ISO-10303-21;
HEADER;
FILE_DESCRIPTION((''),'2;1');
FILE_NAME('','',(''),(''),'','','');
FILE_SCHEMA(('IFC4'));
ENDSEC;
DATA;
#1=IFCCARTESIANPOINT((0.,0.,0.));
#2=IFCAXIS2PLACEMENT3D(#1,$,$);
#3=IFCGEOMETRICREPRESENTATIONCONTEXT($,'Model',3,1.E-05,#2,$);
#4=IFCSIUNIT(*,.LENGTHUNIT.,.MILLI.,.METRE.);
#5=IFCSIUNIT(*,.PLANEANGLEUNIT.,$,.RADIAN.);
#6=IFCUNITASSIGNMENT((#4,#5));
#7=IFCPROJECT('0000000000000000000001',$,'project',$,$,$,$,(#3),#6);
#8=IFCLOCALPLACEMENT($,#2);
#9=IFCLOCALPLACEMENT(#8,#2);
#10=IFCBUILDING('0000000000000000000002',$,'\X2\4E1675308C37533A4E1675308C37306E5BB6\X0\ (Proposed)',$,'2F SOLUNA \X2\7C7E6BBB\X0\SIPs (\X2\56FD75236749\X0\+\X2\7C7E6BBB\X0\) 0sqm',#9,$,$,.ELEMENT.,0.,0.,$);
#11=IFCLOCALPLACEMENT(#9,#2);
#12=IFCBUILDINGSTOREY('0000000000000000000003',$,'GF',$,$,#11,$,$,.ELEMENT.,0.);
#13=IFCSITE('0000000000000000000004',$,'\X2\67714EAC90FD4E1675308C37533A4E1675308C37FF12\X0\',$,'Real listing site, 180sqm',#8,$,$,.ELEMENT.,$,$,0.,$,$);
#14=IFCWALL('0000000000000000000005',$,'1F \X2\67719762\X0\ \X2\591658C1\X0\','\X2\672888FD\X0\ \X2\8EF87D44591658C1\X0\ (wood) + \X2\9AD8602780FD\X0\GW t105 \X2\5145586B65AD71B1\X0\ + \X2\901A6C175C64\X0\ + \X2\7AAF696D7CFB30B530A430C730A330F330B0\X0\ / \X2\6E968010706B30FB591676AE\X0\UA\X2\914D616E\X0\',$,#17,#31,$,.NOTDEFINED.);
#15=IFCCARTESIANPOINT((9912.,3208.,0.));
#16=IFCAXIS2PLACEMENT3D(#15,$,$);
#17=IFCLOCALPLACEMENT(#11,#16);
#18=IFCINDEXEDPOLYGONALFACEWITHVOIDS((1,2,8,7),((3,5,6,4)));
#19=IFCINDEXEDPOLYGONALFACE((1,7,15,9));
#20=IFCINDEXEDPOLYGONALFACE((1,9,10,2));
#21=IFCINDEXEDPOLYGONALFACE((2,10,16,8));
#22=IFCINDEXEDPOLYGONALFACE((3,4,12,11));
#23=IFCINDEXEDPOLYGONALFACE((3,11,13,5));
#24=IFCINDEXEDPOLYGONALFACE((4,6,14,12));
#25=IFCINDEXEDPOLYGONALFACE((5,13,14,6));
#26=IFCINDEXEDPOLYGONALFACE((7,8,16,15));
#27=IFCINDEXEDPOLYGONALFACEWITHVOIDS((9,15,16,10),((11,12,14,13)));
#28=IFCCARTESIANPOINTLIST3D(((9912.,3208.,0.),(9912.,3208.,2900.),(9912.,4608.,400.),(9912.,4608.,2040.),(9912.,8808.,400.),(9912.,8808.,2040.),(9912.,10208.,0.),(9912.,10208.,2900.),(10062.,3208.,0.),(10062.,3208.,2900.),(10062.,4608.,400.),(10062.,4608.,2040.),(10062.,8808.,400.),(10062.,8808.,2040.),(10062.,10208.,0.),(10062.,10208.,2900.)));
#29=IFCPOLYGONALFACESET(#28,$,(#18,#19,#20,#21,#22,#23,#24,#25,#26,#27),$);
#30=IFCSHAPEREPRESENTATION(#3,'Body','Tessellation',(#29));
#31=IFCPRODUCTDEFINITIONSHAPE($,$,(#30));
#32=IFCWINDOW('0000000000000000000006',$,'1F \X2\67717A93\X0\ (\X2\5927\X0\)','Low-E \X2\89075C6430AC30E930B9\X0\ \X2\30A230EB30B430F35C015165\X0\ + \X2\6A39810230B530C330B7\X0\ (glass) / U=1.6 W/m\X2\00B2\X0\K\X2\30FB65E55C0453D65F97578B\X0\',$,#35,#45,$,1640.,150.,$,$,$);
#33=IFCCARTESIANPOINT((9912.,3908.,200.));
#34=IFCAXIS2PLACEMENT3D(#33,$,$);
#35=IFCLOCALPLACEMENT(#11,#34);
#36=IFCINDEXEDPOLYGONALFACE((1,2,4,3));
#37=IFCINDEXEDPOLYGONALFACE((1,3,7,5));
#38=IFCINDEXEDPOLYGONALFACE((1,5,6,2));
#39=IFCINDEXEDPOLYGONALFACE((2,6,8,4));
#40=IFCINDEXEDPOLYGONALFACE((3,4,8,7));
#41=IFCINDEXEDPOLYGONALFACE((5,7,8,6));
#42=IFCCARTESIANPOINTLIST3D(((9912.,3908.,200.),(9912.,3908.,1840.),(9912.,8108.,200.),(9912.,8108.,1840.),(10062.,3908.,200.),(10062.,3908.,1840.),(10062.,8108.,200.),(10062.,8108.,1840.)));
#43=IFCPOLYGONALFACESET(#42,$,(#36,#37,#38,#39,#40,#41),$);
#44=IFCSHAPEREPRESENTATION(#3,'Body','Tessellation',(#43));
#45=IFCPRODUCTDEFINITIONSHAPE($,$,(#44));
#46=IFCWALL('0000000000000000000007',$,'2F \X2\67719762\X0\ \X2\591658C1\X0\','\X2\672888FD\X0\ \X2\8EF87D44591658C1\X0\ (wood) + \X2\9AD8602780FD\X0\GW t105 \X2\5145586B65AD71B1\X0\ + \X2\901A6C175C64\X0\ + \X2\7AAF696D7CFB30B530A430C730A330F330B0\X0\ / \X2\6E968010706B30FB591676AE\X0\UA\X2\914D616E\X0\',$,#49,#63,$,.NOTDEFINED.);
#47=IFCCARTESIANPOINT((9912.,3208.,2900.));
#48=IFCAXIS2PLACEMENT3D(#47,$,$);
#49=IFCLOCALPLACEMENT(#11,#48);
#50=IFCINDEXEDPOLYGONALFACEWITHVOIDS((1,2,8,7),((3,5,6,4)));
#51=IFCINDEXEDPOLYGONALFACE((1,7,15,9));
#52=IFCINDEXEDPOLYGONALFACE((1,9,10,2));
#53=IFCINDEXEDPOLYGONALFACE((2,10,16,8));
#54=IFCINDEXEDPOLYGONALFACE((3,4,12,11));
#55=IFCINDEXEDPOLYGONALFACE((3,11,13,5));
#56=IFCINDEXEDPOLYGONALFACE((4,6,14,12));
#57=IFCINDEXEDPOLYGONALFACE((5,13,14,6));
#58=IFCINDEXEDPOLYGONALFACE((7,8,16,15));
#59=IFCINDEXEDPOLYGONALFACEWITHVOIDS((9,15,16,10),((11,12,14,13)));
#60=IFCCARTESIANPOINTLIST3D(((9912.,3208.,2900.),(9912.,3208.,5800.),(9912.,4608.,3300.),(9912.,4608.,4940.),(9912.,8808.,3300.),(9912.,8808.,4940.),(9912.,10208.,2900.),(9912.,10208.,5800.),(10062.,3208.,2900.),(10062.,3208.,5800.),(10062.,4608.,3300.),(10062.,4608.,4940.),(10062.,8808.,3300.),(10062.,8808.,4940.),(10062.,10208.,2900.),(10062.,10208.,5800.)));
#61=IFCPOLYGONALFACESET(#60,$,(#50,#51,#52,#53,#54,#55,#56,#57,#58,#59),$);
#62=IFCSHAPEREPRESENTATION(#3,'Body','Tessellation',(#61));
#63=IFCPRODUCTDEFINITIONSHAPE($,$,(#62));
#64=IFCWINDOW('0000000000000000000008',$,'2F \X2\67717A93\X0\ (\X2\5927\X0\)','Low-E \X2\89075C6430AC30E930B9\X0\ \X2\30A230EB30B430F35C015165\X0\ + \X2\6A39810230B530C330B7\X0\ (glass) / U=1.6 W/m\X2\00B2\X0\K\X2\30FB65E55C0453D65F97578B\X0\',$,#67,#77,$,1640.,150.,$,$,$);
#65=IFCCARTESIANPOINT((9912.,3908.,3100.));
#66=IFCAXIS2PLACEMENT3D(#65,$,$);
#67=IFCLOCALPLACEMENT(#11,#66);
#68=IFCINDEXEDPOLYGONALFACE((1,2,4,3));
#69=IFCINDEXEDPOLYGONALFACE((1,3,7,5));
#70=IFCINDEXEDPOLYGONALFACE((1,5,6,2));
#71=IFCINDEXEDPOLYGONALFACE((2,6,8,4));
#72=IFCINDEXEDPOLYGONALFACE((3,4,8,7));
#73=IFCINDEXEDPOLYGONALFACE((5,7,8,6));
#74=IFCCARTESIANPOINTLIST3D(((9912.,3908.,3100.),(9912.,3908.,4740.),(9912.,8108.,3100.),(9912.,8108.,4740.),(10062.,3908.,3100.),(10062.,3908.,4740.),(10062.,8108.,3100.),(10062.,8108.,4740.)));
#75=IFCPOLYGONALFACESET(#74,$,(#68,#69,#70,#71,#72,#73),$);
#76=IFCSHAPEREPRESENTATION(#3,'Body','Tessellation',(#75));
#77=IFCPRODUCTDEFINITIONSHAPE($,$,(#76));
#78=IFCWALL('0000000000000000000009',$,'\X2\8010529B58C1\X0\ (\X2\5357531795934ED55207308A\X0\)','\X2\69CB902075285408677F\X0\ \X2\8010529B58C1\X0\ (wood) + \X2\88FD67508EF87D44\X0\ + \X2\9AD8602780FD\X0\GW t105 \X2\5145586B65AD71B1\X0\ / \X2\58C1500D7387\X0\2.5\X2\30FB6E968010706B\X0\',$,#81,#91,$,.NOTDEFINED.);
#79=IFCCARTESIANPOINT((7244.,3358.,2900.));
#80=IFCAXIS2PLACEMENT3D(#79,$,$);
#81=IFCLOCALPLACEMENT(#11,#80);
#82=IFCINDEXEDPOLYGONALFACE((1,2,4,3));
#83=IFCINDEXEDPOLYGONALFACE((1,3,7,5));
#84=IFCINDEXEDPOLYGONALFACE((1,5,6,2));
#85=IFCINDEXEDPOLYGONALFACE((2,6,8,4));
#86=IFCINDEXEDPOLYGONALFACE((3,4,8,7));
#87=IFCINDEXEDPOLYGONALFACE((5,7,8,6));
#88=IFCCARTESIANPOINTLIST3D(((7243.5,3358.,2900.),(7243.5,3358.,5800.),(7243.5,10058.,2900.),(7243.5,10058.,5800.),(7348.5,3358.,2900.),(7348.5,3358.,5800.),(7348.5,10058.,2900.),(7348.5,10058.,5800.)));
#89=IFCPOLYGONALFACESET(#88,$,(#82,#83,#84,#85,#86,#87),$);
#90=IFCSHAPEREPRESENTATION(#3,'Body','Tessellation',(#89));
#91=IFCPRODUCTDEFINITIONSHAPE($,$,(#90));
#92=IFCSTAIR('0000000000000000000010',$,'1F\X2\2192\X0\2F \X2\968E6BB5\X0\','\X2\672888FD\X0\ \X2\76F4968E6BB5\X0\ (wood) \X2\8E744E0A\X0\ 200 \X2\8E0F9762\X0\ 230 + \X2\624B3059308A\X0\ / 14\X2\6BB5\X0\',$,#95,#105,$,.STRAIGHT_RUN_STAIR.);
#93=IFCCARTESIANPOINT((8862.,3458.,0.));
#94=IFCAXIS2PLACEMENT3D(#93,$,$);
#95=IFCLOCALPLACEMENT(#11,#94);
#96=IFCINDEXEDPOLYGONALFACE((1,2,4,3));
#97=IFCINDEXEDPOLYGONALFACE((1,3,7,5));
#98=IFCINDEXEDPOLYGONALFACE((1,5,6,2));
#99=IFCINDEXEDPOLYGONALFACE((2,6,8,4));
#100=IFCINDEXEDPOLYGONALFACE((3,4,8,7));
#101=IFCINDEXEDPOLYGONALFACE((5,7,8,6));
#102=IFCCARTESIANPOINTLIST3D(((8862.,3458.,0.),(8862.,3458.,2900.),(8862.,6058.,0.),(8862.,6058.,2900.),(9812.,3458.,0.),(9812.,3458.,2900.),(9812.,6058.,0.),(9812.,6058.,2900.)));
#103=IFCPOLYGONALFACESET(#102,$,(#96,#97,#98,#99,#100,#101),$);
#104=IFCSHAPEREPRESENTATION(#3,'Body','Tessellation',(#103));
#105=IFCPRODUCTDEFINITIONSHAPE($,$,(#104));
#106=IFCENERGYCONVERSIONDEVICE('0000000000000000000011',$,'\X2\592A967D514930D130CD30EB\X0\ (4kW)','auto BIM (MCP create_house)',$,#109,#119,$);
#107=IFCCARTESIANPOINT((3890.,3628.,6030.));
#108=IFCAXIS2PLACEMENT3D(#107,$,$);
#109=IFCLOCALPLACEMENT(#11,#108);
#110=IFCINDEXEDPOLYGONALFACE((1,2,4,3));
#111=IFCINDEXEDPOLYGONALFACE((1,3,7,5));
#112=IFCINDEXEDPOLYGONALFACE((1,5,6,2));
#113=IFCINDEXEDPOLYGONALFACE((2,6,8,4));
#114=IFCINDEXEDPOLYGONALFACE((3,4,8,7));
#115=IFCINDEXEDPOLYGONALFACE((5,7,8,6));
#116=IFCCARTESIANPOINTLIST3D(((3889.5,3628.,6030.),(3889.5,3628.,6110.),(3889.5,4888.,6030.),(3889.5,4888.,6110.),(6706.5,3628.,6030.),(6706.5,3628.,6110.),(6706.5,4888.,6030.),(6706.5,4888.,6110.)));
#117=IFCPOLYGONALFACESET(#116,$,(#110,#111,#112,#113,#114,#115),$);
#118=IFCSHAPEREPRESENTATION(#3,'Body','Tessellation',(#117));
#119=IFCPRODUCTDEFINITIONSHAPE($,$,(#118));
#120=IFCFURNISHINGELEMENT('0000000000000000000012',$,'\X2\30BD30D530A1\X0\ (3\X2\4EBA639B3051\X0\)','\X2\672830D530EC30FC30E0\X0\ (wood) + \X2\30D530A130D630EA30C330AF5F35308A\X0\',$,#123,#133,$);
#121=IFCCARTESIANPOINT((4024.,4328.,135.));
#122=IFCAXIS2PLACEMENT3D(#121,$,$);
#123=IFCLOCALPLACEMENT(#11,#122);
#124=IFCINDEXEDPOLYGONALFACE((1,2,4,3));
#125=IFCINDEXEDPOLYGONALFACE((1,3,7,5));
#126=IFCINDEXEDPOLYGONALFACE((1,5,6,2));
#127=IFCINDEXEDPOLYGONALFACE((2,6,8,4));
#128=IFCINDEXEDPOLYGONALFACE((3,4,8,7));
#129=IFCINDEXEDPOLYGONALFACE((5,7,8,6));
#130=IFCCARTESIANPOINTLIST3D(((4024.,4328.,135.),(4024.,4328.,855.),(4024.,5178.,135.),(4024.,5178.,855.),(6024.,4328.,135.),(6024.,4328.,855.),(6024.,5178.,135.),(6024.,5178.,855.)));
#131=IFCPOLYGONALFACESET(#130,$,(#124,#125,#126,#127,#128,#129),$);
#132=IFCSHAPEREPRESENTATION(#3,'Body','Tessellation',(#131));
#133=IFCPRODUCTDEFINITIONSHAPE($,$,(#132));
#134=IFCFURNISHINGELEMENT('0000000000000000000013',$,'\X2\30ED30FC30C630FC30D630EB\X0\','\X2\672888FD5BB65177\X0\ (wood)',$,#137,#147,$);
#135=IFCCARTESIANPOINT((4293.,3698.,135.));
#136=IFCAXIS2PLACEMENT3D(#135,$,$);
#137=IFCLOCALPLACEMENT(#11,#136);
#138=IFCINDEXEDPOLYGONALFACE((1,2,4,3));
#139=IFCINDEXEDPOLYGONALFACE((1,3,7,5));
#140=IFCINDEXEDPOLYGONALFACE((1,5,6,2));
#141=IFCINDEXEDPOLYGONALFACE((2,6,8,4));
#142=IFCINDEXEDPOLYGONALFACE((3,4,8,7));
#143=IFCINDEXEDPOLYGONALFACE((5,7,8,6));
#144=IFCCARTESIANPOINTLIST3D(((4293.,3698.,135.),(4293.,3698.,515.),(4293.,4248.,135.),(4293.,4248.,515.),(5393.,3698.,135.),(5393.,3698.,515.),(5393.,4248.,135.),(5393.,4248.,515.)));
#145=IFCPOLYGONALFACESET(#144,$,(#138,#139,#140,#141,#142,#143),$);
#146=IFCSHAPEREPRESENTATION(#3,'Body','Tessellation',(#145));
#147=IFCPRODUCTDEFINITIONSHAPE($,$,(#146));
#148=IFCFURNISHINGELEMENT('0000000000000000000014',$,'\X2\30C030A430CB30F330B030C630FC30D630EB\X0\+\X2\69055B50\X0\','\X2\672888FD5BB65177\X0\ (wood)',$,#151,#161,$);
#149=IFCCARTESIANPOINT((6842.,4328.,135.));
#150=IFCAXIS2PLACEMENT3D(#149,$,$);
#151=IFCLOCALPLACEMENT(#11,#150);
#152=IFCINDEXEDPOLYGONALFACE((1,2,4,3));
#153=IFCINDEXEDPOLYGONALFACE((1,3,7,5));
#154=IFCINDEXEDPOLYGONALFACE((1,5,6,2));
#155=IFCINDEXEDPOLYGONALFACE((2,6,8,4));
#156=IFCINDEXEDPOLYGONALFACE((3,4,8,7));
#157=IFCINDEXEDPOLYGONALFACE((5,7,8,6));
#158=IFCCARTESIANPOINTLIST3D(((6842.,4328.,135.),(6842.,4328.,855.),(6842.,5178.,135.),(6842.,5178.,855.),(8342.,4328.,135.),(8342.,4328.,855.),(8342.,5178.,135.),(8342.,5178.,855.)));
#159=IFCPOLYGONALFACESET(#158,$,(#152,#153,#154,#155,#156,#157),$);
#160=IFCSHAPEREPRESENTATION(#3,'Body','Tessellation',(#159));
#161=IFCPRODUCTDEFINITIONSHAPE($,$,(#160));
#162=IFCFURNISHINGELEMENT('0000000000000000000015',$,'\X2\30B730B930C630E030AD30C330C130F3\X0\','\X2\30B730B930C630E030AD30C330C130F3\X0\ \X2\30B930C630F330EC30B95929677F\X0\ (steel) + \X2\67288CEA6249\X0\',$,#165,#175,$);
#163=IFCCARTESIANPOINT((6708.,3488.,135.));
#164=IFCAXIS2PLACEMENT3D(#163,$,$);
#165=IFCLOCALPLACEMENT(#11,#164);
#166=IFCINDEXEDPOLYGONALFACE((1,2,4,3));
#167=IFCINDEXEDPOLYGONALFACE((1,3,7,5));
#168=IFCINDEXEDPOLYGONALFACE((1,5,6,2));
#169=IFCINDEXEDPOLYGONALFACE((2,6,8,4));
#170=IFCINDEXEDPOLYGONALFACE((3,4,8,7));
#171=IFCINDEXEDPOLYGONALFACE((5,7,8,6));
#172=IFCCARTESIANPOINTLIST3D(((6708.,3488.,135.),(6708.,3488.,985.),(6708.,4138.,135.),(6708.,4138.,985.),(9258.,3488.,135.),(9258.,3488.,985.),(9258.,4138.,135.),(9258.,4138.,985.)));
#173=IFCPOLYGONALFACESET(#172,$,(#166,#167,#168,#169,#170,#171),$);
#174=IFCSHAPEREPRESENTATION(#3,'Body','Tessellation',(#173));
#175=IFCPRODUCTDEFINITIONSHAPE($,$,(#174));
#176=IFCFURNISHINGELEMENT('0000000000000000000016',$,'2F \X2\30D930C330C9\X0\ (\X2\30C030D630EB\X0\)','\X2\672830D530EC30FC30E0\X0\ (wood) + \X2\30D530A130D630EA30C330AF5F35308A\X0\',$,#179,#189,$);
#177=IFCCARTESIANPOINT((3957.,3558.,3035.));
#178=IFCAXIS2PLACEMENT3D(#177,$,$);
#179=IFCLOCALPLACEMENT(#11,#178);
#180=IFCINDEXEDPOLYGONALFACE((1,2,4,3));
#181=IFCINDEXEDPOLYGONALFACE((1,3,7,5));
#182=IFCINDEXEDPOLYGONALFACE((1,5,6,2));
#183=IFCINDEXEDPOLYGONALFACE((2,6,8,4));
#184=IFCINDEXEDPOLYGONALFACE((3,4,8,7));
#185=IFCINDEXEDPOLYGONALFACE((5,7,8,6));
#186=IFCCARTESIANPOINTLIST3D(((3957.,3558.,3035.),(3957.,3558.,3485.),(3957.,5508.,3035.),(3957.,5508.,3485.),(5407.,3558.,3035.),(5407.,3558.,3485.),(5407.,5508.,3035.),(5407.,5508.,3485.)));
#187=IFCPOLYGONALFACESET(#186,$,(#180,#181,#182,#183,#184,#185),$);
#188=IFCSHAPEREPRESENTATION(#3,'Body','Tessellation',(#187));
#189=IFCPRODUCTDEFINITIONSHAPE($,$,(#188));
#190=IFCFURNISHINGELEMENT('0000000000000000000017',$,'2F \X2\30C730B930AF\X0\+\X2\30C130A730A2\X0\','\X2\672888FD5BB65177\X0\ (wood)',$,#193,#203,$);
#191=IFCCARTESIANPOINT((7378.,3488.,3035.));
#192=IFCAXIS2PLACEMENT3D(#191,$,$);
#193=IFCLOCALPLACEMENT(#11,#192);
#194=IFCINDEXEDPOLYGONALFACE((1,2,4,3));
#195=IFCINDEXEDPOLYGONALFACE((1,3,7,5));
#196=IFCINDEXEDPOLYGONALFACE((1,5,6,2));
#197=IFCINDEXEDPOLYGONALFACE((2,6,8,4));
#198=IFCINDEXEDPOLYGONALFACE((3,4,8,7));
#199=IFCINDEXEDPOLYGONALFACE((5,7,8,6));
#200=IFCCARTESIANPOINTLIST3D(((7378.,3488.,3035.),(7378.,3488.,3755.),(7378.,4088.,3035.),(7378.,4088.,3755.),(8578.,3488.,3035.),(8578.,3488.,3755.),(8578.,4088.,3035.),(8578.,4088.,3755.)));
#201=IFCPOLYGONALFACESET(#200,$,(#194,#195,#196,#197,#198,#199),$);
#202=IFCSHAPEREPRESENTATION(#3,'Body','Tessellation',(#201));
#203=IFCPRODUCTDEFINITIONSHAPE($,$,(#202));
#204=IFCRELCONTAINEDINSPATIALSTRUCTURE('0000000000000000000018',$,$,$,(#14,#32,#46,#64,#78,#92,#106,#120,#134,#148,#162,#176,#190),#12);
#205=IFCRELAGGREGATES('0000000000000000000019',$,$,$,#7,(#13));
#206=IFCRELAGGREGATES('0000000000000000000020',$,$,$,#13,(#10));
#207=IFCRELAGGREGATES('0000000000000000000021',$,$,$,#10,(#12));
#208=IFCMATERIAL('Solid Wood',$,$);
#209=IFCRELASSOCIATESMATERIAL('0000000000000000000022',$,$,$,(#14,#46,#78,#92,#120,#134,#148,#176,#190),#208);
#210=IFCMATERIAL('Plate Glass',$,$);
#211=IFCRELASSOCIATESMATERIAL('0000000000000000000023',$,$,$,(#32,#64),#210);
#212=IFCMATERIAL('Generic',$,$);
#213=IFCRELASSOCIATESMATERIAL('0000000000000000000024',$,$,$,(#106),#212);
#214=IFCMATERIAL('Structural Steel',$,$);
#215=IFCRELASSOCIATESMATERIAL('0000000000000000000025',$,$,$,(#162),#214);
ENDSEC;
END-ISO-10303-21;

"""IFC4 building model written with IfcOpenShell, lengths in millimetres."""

from ifc_helpers import new_model, si_unit, frame, frame_2d, origin, place, context, project, spatial, rectangle, extrude, material, element, fill, save


model = new_model("IFC4")

# Units and contexts
model_context = context("Model", 3, precision=1e-05, world=origin())
ifc_project = project(units=[si_unit("LENGTHUNIT", "METRE", prefix="MILLI"), si_unit("PLANEANGLEUNIT", "RADIAN")], contexts=[model_context])

# Site, building, storey
site_placement = place(None, origin())
site = spatial("IfcSite", under=ifc_project, at=site_placement, Name="東京都世田谷区世田谷２", ObjectType="Real listing site, 180sqm", CompositionType="ELEMENT", RefElevation=0.0)
building_placement = place(site_placement, origin())
building = spatial("IfcBuilding", under=site, at=building_placement, Name="世田谷区世田谷の家 (Proposed)", ObjectType="2F SOLUNA 籾殻SIPs (国産杉+籾殻) 0sqm", CompositionType="ELEMENT", ElevationOfRefHeight=0.0, ElevationOfTerrain=0.0)
storey_placement = place(building_placement, origin())
storey = spatial("IfcBuildingStorey", under=building, at=storey_placement, Name="GF", CompositionType="ELEMENT", Elevation=0.0)

# Wall, opening, window
ifc_material_1 = material(Name="Solid Wood")
wall_1_placement = place(storey_placement, frame((9912.0, 3208.0, 0.0)))
wall_1 = element("IfcWall", 1, at=wall_1_placement, inside=storey, material=ifc_material_1, Name="1F 東面 外壁", Description="木製 軸組外壁 (wood) + 高性能GW t105 充填断熱 + 通気層 + 窯業系サイディング / 準耐火・外皮UA配慮", PredefinedType="NOTDEFINED", context=model_context, shape_type="SweptSolid", body=[
    extrude(rectangle(XDim=150.0, YDim=7000.0, at=frame_2d((75.0, 3500.0))), frame((9912.0, 3208.0, 0.0)), (0.0, 0.0, 1.0), 2900.0),
])
opening_1_placement = place(storey_placement, frame((9912.0, 3908.0, 200.0)))
opening_1 = element("IfcOpeningElement", 2, at=opening_1_placement, cuts=wall_1, PredefinedType="NOTDEFINED", context=model_context, shape_type="SweptSolid", body=[
    extrude(rectangle(XDim=150.0, YDim=4200.0, at=frame_2d((75.0, 2100.0))), frame((9912.0, 3908.0, 200.0)), (0.0, 0.0, 1.0), 1640.0),
])
ifc_material_2 = material(Name="Plate Glass")
window_1_placement = place(storey_placement, frame((9912.0, 3908.0, 200.0)))
window_1 = element("IfcWindow", 3, at=window_1_placement, inside=storey, material=ifc_material_2, Name="1F 東窓 (大)", Description="Low-E 複層ガラス アルゴン封入 + 樹脂サッシ (glass) / U=1.6 W/m²K・日射取得型", OverallHeight=1640.0, OverallWidth=150.0, context=model_context, shape_type="SweptSolid", body=[
    extrude(rectangle(XDim=150.0, YDim=4200.0, at=frame_2d((75.0, 2100.0))), frame((9912.0, 3908.0, 200.0)), (0.0, 0.0, 1.0), 1640.0),
])
fill(opening_1, window_1)

# Wall, opening, window
wall_2_placement = place(storey_placement, frame((9912.0, 3208.0, 2900.0)))
wall_2 = element("IfcWall", 4, at=wall_2_placement, inside=storey, material=ifc_material_1, Name="2F 東面 外壁", Description="木製 軸組外壁 (wood) + 高性能GW t105 充填断熱 + 通気層 + 窯業系サイディング / 準耐火・外皮UA配慮", PredefinedType="NOTDEFINED", context=model_context, shape_type="SweptSolid", body=[
    extrude(rectangle(XDim=150.0, YDim=7000.0, at=frame_2d((75.0, 3500.0))), frame((9912.0, 3208.0, 2900.0)), (0.0, 0.0, 1.0), 2900.0),
])
opening_2_placement = place(storey_placement, frame((9912.0, 3908.0, 3100.0)))
opening_2 = element("IfcOpeningElement", 5, at=opening_2_placement, cuts=wall_2, PredefinedType="NOTDEFINED", context=model_context, shape_type="SweptSolid", body=[
    extrude(rectangle(XDim=150.0, YDim=4200.0, at=frame_2d((75.0, 2100.0))), frame((9912.0, 3908.0, 3100.0)), (0.0, 0.0, 1.0), 1640.0),
])
window_2_placement = place(storey_placement, frame((9912.0, 3908.0, 3100.0)))
window_2 = element("IfcWindow", 6, at=window_2_placement, inside=storey, material=ifc_material_2, Name="2F 東窓 (大)", Description="Low-E 複層ガラス アルゴン封入 + 樹脂サッシ (glass) / U=1.6 W/m²K・日射取得型", OverallHeight=1640.0, OverallWidth=150.0, context=model_context, shape_type="SweptSolid", body=[
    extrude(rectangle(XDim=150.0, YDim=4200.0, at=frame_2d((75.0, 2100.0))), frame((9912.0, 3908.0, 3100.0)), (0.0, 0.0, 1.0), 1640.0),
])
fill(opening_2, window_2)

# Wall
wall_3_placement = place(storey_placement, frame((7244.0, 3358.0, 2900.0)))
element("IfcWall", 7, at=wall_3_placement, inside=storey, material=ifc_material_1, Name="耐力壁 (南北間仕切り)", Description="構造用合板 耐力壁 (wood) + 製材軸組 + 高性能GW t105 充填断熱 / 壁倍率2.5・準耐火", PredefinedType="NOTDEFINED", context=model_context, shape_type="SweptSolid", body=[
    extrude(rectangle(XDim=105.0, YDim=6700.0, at=frame_2d((52.0, 3350.0))), frame((7244.0, 3358.0, 2900.0)), (0.0, 0.0, 1.0), 2900.0),
])

# Stair
stair_placement = place(storey_placement, frame((8862.0, 3458.0, 0.0)))
element("IfcStair", 8, at=stair_placement, inside=storey, material=ifc_material_1, Name="1F→2F 階段", Description="木製 直階段 (wood) 蹴上 200 踏面 230 + 手すり / 14段", PredefinedType="STRAIGHT_RUN_STAIR", context=model_context, shape_type="SweptSolid", body=[
    extrude(rectangle(XDim=950.0, YDim=2600.0, at=frame_2d((475.0, 1300.0))), frame((8862.0, 3458.0, 0.0)), (0.0, 0.0, 1.0), 2900.0),
])

# Energy conversion device
ifc_material_3 = material(Name="Generic")
energy_conversion_device_placement = place(storey_placement, frame((3890.0, 3628.0, 6030.0)))
element("IfcEnergyConversionDevice", 9, at=energy_conversion_device_placement, inside=storey, material=ifc_material_3, Name="太陽光パネル (4kW)", Description="auto BIM (MCP create_house)", context=model_context, shape_type="SweptSolid", body=[
    extrude(rectangle(XDim=2817.0, YDim=1260.0, at=frame_2d((1408.0, 630.0))), frame((3890.0, 3628.0, 6030.0)), (0.0, 0.0, 1.0), 80.0),
])

# Furnishing elements
furnishing_1_placement = place(storey_placement, frame((4024.0, 4328.0, 135.0)))
element("IfcFurnishingElement", 10, at=furnishing_1_placement, inside=storey, material=ifc_material_1, Name="ソファ (3人掛け)", Description="木フレーム (wood) + ファブリック張り", context=model_context, shape_type="SweptSolid", body=[
    extrude(rectangle(XDim=2000.0, YDim=850.0, at=frame_2d((1000.0, 425.0))), frame((4024.0, 4328.0, 135.0)), (0.0, 0.0, 1.0), 720.0),
])
furnishing_2_placement = place(storey_placement, frame((4293.0, 3698.0, 135.0)))
element("IfcFurnishingElement", 11, at=furnishing_2_placement, inside=storey, material=ifc_material_1, Name="ローテーブル", Description="木製家具 (wood)", context=model_context, shape_type="SweptSolid", body=[
    extrude(rectangle(XDim=1100.0, YDim=550.0, at=frame_2d((550.0, 275.0))), frame((4293.0, 3698.0, 135.0)), (0.0, 0.0, 1.0), 380.0),
])
furnishing_3_placement = place(storey_placement, frame((6842.0, 4328.0, 135.0)))
element("IfcFurnishingElement", 12, at=furnishing_3_placement, inside=storey, material=ifc_material_1, Name="ダイニングテーブル+椅子", Description="木製家具 (wood)", context=model_context, shape_type="SweptSolid", body=[
    extrude(rectangle(XDim=1500.0, YDim=850.0, at=frame_2d((750.0, 425.0))), frame((6842.0, 4328.0, 135.0)), (0.0, 0.0, 1.0), 720.0),
])
ifc_material_4 = material(Name="Structural Steel")
furnishing_4_placement = place(storey_placement, frame((6708.0, 3488.0, 135.0)))
element("IfcFurnishingElement", 13, at=furnishing_4_placement, inside=storey, material=ifc_material_4, Name="システムキッチン", Description="システムキッチン ステンレス天板 (steel) + 木質扉", context=model_context, shape_type="SweptSolid", body=[
    extrude(rectangle(XDim=2550.0, YDim=650.0, at=frame_2d((1275.0, 325.0))), frame((6708.0, 3488.0, 135.0)), (0.0, 0.0, 1.0), 850.0),
])
furnishing_5_placement = place(storey_placement, frame((3957.0, 3558.0, 3035.0)))
element("IfcFurnishingElement", 14, at=furnishing_5_placement, inside=storey, material=ifc_material_1, Name="2F ベッド (ダブル)", Description="木フレーム (wood) + ファブリック張り", context=model_context, shape_type="SweptSolid", body=[
    extrude(rectangle(XDim=1450.0, YDim=1950.0, at=frame_2d((725.0, 975.0))), frame((3957.0, 3558.0, 3035.0)), (0.0, 0.0, 1.0), 450.0),
])
furnishing_6_placement = place(storey_placement, frame((7378.0, 3488.0, 3035.0)))
element("IfcFurnishingElement", 15, at=furnishing_6_placement, inside=storey, material=ifc_material_1, Name="2F デスク+チェア", Description="木製家具 (wood)", context=model_context, shape_type="SweptSolid", body=[
    extrude(rectangle(XDim=1200.0, YDim=600.0, at=frame_2d((600.0, 300.0))), frame((7378.0, 3488.0, 3035.0)), (0.0, 0.0, 1.0), 720.0),
])

save(model, "model.ifc")
